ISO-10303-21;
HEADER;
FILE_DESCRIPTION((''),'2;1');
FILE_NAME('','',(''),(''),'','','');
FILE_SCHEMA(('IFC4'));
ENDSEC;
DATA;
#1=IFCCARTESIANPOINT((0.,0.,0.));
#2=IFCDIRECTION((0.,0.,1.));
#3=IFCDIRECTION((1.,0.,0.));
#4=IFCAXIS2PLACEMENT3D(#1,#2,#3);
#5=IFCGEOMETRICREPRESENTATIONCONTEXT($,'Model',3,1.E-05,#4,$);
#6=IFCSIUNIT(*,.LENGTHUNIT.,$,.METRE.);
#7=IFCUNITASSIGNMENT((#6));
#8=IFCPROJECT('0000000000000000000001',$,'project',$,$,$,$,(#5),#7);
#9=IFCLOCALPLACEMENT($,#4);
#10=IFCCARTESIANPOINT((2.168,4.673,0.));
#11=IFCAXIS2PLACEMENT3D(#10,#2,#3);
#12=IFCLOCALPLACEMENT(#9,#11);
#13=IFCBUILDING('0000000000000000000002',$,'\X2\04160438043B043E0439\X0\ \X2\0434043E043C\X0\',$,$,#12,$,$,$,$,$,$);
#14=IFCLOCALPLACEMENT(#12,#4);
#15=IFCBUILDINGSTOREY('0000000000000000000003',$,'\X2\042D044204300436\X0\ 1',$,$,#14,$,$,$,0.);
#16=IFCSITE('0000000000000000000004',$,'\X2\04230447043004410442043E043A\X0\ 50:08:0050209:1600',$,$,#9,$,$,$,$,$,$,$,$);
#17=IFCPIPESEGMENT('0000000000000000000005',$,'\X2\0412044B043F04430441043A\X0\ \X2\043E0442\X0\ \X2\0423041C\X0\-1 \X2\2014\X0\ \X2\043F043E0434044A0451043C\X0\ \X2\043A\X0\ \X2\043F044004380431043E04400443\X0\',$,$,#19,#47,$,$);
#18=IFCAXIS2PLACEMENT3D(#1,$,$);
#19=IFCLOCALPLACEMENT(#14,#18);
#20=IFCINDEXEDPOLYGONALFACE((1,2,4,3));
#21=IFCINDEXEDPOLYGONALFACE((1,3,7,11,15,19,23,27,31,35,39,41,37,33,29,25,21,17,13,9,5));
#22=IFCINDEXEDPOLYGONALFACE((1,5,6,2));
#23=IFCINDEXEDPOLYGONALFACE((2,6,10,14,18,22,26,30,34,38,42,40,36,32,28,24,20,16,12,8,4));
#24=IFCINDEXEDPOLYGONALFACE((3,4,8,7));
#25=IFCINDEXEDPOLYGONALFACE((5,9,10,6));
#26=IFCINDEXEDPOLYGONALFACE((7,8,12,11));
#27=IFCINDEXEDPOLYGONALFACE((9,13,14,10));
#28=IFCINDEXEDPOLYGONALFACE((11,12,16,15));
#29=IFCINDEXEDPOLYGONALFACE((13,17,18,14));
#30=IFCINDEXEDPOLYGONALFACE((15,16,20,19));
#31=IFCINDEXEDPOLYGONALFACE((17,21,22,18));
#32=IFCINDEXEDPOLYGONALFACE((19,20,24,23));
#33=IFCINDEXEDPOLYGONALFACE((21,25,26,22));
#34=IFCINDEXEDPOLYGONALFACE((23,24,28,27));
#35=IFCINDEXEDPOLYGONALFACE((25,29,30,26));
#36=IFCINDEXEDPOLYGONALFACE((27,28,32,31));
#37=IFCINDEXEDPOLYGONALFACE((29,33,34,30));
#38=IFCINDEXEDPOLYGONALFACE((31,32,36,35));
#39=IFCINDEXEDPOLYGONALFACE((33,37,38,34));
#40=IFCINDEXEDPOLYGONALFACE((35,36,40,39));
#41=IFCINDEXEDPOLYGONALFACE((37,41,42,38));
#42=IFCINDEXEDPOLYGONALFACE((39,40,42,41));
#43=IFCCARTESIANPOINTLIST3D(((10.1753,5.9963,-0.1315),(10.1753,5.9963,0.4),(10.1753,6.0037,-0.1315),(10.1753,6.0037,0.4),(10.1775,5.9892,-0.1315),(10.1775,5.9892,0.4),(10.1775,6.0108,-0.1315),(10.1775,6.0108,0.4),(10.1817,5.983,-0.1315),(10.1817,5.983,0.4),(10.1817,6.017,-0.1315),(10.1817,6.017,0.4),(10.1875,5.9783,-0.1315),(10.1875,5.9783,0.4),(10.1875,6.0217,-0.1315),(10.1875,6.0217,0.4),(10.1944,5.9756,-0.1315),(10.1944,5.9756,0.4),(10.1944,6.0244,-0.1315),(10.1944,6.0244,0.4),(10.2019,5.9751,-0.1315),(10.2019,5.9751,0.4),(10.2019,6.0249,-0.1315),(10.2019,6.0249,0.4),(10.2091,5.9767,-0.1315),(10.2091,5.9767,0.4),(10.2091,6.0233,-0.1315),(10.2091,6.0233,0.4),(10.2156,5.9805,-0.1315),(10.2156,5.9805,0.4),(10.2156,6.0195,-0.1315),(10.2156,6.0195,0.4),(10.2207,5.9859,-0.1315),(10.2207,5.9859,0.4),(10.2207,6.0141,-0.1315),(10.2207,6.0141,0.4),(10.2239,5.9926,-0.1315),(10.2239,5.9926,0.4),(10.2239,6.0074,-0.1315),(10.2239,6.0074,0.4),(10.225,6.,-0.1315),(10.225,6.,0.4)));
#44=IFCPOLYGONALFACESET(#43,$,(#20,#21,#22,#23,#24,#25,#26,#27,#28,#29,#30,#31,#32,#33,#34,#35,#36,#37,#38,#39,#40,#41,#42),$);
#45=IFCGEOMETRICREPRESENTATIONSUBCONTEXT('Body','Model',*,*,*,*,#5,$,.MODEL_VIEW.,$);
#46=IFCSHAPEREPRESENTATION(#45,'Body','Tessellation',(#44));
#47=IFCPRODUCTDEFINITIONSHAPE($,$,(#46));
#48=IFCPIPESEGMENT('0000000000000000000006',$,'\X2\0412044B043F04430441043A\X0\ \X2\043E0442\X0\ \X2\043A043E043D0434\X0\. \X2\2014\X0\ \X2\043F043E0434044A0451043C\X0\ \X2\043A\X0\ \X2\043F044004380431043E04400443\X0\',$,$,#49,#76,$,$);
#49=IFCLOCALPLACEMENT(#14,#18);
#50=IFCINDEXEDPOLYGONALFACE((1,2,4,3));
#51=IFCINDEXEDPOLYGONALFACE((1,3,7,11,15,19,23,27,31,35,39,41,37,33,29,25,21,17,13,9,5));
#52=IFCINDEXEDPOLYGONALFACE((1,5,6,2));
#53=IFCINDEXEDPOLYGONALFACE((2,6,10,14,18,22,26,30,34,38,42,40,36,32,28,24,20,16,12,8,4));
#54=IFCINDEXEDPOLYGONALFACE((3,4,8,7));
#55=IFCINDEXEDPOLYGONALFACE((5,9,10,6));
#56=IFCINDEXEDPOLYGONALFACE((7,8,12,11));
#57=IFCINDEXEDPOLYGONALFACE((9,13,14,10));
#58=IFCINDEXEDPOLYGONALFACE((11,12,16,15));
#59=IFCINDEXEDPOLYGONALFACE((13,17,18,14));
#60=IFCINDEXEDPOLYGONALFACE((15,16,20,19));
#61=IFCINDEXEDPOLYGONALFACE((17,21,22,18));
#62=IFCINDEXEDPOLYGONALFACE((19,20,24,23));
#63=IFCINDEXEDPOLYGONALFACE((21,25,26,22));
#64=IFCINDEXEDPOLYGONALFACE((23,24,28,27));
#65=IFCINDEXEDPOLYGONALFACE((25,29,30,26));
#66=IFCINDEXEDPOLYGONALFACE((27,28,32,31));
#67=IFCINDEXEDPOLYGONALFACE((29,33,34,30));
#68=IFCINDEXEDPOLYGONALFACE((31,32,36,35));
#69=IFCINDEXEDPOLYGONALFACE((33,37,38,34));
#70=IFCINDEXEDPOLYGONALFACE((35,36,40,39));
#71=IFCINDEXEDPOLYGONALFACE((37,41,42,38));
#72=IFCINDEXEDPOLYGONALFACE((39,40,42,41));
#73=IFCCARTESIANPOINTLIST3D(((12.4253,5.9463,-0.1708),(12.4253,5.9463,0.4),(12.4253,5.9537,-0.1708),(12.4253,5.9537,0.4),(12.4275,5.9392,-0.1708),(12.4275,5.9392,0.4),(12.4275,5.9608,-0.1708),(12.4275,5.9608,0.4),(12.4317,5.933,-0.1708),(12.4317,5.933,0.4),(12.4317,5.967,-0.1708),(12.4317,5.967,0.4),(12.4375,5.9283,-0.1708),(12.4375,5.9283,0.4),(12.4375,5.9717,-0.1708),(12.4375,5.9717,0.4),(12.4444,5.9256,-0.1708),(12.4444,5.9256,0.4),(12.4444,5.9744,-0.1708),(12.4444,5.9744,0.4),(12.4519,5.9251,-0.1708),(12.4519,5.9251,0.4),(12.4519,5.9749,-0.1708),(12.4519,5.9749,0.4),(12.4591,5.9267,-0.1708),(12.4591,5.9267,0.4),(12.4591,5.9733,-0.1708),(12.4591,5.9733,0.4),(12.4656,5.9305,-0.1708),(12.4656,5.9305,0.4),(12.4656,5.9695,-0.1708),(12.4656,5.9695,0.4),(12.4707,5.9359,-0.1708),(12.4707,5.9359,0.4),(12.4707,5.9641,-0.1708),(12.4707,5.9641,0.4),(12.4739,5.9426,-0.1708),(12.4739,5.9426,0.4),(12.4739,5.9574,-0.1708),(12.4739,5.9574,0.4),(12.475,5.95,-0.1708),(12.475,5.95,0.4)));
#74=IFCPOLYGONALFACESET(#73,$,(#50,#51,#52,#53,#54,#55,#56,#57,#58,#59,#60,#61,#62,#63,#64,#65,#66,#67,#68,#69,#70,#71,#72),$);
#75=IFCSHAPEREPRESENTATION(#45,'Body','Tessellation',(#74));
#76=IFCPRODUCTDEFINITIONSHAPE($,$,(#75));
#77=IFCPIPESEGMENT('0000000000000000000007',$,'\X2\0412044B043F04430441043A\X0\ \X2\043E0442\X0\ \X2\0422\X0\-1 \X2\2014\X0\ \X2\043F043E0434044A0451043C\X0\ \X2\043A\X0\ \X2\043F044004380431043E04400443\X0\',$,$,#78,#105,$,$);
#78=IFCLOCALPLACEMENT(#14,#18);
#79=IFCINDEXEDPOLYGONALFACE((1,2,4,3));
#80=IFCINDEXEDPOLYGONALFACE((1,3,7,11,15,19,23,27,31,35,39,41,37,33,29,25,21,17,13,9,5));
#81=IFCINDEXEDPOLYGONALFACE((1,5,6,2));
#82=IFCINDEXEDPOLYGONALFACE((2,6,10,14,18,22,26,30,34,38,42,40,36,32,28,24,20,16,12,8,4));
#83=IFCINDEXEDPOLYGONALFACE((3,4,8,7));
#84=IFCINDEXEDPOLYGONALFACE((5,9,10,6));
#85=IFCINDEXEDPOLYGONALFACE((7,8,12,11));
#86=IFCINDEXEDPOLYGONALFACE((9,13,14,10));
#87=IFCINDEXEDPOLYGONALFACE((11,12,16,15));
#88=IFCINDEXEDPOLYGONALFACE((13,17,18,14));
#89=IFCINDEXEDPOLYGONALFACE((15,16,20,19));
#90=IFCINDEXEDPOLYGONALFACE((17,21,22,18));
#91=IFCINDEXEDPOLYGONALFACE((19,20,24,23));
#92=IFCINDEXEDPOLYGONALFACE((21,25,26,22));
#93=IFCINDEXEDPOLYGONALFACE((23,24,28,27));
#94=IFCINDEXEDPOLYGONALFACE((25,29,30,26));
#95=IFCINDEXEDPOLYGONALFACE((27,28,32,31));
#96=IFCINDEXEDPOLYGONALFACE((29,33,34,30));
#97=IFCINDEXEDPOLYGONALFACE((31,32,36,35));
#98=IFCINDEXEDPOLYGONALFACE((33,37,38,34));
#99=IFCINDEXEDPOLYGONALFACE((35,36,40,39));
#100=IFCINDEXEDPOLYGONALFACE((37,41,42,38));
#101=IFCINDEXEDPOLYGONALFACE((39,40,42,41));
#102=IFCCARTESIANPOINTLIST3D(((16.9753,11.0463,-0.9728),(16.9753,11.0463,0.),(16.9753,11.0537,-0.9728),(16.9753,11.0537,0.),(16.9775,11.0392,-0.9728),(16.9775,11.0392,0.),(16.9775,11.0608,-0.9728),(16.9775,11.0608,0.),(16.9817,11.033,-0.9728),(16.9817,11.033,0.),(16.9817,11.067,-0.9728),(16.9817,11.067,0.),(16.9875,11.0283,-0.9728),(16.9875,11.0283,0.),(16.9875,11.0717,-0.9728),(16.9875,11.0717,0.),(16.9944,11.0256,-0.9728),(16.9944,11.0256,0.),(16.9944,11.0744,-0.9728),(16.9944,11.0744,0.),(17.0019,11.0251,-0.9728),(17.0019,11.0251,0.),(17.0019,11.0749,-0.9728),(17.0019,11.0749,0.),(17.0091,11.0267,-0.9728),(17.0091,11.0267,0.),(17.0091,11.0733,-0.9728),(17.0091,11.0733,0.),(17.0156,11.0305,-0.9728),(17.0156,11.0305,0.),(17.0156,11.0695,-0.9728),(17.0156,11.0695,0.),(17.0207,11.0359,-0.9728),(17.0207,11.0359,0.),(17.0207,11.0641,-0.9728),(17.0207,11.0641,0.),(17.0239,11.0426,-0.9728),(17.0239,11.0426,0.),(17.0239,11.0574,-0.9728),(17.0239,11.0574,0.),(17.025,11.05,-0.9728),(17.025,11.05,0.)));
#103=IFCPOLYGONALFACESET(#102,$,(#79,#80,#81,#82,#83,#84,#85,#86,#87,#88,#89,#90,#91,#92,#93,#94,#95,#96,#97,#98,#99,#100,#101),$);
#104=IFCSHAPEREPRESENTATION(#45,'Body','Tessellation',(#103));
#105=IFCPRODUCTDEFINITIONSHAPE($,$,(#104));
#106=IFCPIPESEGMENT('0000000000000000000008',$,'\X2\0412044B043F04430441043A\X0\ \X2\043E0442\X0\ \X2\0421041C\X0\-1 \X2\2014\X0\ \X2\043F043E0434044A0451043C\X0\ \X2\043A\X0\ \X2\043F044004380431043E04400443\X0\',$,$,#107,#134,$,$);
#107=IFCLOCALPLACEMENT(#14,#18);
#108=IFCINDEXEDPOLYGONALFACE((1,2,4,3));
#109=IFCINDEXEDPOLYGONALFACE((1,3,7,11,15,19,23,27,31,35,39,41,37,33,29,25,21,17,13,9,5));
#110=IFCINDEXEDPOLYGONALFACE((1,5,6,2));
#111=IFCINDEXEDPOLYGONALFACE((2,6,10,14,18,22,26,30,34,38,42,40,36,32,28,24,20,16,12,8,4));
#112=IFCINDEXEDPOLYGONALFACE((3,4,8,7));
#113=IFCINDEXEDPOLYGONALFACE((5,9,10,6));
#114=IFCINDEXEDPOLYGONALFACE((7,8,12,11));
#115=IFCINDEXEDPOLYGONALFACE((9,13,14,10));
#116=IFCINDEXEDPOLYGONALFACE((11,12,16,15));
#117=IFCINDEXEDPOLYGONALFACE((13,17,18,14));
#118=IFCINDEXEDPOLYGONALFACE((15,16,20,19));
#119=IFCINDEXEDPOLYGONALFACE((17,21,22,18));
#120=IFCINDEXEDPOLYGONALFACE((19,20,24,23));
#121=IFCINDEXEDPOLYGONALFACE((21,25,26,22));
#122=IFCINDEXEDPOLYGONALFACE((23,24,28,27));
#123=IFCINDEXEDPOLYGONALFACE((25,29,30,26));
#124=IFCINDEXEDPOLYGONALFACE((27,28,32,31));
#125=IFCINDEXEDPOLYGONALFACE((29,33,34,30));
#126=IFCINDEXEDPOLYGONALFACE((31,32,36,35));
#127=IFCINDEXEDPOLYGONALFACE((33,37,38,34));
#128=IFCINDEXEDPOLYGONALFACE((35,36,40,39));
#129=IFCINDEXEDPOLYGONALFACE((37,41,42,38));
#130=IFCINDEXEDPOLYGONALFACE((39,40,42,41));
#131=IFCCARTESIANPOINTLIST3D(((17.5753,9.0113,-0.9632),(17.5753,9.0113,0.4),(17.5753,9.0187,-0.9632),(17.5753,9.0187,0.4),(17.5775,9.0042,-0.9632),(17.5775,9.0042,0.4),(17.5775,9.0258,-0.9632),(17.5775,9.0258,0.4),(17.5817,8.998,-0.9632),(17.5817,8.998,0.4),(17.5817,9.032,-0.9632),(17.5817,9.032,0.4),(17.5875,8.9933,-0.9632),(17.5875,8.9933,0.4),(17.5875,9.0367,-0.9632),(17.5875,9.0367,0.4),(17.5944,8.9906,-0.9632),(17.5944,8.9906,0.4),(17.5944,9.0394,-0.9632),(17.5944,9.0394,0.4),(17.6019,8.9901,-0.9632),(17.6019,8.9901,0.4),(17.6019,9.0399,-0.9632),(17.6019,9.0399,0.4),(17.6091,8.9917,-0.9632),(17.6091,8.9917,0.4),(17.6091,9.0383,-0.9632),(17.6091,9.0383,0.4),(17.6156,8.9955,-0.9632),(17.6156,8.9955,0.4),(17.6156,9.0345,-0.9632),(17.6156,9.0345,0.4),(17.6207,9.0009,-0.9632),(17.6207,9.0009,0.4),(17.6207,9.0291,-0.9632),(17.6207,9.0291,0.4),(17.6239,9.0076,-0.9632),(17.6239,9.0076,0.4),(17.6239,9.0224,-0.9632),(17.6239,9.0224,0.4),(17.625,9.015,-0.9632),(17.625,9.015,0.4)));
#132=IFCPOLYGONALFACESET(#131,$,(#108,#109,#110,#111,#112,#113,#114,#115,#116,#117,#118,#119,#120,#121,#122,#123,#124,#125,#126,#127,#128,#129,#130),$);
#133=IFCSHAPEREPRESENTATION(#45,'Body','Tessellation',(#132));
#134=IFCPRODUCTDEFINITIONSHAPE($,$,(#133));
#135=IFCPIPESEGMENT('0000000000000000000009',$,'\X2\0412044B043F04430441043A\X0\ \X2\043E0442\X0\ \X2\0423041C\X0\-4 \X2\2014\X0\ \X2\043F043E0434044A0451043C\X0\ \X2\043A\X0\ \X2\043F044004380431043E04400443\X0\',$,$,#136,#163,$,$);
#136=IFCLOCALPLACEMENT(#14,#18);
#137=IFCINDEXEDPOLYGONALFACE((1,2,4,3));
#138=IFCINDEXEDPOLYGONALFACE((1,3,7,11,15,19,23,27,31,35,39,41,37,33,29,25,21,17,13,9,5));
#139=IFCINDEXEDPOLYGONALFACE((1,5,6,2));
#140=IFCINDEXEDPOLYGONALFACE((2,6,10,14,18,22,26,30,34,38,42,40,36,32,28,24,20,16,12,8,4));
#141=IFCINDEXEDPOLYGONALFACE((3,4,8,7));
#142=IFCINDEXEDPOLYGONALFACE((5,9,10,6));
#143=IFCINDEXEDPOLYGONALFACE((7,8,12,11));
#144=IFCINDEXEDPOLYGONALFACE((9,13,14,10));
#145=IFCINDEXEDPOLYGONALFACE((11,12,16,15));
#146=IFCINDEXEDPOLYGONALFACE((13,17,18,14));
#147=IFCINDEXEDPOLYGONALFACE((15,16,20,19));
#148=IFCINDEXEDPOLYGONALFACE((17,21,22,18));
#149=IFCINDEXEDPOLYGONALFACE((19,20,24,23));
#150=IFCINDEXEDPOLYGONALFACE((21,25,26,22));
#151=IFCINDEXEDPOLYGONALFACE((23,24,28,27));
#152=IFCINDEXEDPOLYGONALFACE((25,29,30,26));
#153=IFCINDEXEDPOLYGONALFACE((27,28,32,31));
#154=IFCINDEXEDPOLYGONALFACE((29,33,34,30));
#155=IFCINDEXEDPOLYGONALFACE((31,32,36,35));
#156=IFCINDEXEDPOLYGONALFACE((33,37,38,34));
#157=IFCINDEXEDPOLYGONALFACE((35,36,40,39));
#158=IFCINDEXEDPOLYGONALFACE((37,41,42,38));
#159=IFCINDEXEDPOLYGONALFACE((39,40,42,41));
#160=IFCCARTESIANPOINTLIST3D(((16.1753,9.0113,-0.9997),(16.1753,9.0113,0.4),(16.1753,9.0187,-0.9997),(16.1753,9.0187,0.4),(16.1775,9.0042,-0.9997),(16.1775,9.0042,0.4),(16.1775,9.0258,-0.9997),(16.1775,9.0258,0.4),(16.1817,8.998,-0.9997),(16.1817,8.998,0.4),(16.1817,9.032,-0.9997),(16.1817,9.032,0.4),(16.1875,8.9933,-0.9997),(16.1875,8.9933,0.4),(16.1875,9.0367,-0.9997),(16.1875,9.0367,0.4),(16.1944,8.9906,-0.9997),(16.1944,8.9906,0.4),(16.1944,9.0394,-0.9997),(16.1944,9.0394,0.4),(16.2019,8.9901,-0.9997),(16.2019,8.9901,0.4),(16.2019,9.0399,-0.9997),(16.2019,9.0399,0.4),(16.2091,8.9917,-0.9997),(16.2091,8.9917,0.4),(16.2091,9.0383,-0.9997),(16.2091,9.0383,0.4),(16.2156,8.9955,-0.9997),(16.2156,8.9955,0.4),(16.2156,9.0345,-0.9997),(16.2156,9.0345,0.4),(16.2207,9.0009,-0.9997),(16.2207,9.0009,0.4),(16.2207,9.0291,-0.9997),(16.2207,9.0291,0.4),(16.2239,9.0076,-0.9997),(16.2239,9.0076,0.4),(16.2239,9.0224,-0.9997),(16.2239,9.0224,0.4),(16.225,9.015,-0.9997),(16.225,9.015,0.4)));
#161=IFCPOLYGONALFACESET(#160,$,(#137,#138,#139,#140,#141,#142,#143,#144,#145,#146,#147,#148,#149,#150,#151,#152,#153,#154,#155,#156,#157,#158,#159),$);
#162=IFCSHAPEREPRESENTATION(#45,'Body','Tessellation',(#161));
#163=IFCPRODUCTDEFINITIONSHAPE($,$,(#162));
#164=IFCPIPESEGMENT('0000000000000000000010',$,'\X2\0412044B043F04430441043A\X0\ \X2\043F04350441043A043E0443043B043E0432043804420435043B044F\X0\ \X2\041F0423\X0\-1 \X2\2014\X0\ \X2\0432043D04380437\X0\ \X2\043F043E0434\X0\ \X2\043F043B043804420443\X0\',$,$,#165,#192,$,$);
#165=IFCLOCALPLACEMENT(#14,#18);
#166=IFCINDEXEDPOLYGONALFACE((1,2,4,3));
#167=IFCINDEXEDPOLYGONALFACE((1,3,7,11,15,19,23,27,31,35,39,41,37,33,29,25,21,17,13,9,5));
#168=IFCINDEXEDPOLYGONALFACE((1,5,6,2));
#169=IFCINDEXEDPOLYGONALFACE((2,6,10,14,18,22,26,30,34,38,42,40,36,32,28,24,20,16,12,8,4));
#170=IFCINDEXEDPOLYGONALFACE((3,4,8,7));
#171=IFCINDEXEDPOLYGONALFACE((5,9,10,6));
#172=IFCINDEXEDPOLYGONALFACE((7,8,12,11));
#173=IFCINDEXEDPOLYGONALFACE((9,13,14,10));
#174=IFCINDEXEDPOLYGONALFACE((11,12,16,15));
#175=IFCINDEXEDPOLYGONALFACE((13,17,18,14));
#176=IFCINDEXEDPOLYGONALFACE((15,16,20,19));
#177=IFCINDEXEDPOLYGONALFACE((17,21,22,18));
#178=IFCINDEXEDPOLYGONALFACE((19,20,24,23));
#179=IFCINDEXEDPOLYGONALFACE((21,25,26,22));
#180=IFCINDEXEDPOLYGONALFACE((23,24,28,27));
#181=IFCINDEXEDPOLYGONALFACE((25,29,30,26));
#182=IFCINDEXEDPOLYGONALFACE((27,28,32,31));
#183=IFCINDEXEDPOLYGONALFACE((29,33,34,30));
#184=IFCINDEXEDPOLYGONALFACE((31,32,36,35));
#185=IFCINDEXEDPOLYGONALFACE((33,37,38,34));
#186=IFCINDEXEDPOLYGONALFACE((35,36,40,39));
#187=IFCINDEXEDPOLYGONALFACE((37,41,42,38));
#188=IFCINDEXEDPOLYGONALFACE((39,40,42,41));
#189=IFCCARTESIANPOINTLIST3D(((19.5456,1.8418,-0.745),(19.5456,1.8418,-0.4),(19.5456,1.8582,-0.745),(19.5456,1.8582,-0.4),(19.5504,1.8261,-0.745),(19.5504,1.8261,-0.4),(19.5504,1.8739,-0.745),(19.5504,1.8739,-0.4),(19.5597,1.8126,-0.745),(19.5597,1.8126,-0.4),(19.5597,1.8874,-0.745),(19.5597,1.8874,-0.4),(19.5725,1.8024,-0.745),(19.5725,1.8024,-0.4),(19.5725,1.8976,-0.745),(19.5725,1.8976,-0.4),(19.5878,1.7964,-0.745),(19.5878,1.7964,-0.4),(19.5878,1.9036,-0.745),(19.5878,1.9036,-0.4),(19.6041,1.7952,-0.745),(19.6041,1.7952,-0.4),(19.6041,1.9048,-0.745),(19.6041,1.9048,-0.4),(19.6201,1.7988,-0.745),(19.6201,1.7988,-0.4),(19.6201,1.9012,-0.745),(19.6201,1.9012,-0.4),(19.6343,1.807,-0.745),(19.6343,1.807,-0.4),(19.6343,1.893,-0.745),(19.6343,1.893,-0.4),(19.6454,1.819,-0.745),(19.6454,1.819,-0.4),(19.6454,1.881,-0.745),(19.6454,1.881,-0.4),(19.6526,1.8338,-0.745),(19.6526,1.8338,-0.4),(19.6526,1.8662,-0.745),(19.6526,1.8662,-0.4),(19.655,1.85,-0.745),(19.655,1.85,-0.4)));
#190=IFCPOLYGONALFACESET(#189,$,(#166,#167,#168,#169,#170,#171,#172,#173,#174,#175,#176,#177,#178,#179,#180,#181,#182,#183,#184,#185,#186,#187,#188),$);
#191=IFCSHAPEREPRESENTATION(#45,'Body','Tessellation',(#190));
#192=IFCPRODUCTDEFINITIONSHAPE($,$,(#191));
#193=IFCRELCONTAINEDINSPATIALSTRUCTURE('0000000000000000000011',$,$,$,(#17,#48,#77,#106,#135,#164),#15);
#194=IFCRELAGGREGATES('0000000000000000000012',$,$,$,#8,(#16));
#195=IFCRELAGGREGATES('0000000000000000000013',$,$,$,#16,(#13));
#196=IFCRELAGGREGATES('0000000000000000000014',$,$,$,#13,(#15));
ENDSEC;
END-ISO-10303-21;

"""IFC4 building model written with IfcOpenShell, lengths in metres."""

from ifc_helpers import new_model, si_unit, frame, origin_with_axes, origin_2d, place, context, subcontext, project, spatial, circle, extrude, element, save


model = new_model("IFC4")

# Units and contexts
model_context = context("Model", 3, precision=1e-05, world=origin_with_axes())
body_context = subcontext(model_context, "Body", "Model", "MODEL_VIEW")
ifc_project = project(units=[si_unit("LENGTHUNIT", "METRE")], contexts=[model_context])

# Site, building, storey
site_placement = place(None, origin_with_axes())
site = spatial("IfcSite", under=ifc_project, at=site_placement, Name="Участок 50:08:0050209:1600")
building_placement = place(site_placement, frame((2.168, 4.673, 0.0), z_axis=(0.0, 0.0, 1.0), x_axis=(1.0, 0.0, 0.0)))
building = spatial("IfcBuilding", under=site, at=building_placement, Name="Жилой дом")
storey_placement = place(building_placement, origin_with_axes())
storey = spatial("IfcBuildingStorey", under=building, at=storey_placement, Name="Этаж 1", Elevation=0.0)

# Pipe segments
pipe_segment_1_placement = place(storey_placement, origin_with_axes())
element("IfcPipeSegment", 1, at=pipe_segment_1_placement, inside=storey, Name="Выпуск от УМ-1 — подъём к прибору", context=body_context, shape_type="SweptSolid", body=[
    extrude(circle(Radius=0.025, at=origin_2d()), frame((10.2, 6.0, 0.4), z_axis=(0.0, 0.0, -1.0), x_axis=(1.0, 0.0, 0.0)), (0.0, 0.0, 1.0), 0.5315),
])
pipe_segment_2_placement = place(storey_placement, origin_with_axes())
element("IfcPipeSegment", 2, at=pipe_segment_2_placement, inside=storey, Name="Выпуск от конд. — подъём к прибору", context=body_context, shape_type="SweptSolid", body=[
    extrude(circle(Radius=0.025, at=origin_2d()), frame((12.45, 5.95, 0.4), z_axis=(0.0, 0.0, -1.0), x_axis=(1.0, 0.0, 0.0)), (0.0, 0.0, 1.0), 0.5708),
])
pipe_segment_3_placement = place(storey_placement, origin_with_axes())
element("IfcPipeSegment", 3, at=pipe_segment_3_placement, inside=storey, Name="Выпуск от Т-1 — подъём к прибору", context=body_context, shape_type="SweptSolid", body=[
    extrude(circle(Radius=0.025, at=origin_2d()), frame((17.0, 11.05, 0.0), z_axis=(0.0, 0.0, -1.0), x_axis=(1.0, 0.0, 0.0)), (0.0, 0.0, 1.0), 0.9728),
])
pipe_segment_4_placement = place(storey_placement, origin_with_axes())
element("IfcPipeSegment", 4, at=pipe_segment_4_placement, inside=storey, Name="Выпуск от СМ-1 — подъём к прибору", context=body_context, shape_type="SweptSolid", body=[
    extrude(circle(Radius=0.025, at=origin_2d()), frame((17.6, 9.015, 0.4), z_axis=(0.0, 0.0, -1.0), x_axis=(1.0, 0.0, 0.0)), (0.0, 0.0, 1.0), 1.3632),
])
pipe_segment_5_placement = place(storey_placement, origin_with_axes())
element("IfcPipeSegment", 5, at=pipe_segment_5_placement, inside=storey, Name="Выпуск от УМ-4 — подъём к прибору", context=body_context, shape_type="SweptSolid", body=[
    extrude(circle(Radius=0.025, at=origin_2d()), frame((16.2, 9.015, 0.4), z_axis=(0.0, 0.0, -1.0), x_axis=(1.0, 0.0, 0.0)), (0.0, 0.0, 1.0), 1.3997),
])
pipe_segment_6_placement = place(storey_placement, origin_with_axes())
element("IfcPipeSegment", 6, at=pipe_segment_6_placement, inside=storey, Name="Выпуск пескоуловителя ПУ-1 — вниз под плиту", context=body_context, shape_type="SweptSolid", body=[
    extrude(circle(Radius=0.055, at=origin_2d()), frame((19.6, 1.85, -0.4), z_axis=(0.0, 0.0, -1.0), x_axis=(1.0, 0.0, 0.0)), (0.0, 0.0, 1.0), 0.345),
])

save(model, "model.ifc")
